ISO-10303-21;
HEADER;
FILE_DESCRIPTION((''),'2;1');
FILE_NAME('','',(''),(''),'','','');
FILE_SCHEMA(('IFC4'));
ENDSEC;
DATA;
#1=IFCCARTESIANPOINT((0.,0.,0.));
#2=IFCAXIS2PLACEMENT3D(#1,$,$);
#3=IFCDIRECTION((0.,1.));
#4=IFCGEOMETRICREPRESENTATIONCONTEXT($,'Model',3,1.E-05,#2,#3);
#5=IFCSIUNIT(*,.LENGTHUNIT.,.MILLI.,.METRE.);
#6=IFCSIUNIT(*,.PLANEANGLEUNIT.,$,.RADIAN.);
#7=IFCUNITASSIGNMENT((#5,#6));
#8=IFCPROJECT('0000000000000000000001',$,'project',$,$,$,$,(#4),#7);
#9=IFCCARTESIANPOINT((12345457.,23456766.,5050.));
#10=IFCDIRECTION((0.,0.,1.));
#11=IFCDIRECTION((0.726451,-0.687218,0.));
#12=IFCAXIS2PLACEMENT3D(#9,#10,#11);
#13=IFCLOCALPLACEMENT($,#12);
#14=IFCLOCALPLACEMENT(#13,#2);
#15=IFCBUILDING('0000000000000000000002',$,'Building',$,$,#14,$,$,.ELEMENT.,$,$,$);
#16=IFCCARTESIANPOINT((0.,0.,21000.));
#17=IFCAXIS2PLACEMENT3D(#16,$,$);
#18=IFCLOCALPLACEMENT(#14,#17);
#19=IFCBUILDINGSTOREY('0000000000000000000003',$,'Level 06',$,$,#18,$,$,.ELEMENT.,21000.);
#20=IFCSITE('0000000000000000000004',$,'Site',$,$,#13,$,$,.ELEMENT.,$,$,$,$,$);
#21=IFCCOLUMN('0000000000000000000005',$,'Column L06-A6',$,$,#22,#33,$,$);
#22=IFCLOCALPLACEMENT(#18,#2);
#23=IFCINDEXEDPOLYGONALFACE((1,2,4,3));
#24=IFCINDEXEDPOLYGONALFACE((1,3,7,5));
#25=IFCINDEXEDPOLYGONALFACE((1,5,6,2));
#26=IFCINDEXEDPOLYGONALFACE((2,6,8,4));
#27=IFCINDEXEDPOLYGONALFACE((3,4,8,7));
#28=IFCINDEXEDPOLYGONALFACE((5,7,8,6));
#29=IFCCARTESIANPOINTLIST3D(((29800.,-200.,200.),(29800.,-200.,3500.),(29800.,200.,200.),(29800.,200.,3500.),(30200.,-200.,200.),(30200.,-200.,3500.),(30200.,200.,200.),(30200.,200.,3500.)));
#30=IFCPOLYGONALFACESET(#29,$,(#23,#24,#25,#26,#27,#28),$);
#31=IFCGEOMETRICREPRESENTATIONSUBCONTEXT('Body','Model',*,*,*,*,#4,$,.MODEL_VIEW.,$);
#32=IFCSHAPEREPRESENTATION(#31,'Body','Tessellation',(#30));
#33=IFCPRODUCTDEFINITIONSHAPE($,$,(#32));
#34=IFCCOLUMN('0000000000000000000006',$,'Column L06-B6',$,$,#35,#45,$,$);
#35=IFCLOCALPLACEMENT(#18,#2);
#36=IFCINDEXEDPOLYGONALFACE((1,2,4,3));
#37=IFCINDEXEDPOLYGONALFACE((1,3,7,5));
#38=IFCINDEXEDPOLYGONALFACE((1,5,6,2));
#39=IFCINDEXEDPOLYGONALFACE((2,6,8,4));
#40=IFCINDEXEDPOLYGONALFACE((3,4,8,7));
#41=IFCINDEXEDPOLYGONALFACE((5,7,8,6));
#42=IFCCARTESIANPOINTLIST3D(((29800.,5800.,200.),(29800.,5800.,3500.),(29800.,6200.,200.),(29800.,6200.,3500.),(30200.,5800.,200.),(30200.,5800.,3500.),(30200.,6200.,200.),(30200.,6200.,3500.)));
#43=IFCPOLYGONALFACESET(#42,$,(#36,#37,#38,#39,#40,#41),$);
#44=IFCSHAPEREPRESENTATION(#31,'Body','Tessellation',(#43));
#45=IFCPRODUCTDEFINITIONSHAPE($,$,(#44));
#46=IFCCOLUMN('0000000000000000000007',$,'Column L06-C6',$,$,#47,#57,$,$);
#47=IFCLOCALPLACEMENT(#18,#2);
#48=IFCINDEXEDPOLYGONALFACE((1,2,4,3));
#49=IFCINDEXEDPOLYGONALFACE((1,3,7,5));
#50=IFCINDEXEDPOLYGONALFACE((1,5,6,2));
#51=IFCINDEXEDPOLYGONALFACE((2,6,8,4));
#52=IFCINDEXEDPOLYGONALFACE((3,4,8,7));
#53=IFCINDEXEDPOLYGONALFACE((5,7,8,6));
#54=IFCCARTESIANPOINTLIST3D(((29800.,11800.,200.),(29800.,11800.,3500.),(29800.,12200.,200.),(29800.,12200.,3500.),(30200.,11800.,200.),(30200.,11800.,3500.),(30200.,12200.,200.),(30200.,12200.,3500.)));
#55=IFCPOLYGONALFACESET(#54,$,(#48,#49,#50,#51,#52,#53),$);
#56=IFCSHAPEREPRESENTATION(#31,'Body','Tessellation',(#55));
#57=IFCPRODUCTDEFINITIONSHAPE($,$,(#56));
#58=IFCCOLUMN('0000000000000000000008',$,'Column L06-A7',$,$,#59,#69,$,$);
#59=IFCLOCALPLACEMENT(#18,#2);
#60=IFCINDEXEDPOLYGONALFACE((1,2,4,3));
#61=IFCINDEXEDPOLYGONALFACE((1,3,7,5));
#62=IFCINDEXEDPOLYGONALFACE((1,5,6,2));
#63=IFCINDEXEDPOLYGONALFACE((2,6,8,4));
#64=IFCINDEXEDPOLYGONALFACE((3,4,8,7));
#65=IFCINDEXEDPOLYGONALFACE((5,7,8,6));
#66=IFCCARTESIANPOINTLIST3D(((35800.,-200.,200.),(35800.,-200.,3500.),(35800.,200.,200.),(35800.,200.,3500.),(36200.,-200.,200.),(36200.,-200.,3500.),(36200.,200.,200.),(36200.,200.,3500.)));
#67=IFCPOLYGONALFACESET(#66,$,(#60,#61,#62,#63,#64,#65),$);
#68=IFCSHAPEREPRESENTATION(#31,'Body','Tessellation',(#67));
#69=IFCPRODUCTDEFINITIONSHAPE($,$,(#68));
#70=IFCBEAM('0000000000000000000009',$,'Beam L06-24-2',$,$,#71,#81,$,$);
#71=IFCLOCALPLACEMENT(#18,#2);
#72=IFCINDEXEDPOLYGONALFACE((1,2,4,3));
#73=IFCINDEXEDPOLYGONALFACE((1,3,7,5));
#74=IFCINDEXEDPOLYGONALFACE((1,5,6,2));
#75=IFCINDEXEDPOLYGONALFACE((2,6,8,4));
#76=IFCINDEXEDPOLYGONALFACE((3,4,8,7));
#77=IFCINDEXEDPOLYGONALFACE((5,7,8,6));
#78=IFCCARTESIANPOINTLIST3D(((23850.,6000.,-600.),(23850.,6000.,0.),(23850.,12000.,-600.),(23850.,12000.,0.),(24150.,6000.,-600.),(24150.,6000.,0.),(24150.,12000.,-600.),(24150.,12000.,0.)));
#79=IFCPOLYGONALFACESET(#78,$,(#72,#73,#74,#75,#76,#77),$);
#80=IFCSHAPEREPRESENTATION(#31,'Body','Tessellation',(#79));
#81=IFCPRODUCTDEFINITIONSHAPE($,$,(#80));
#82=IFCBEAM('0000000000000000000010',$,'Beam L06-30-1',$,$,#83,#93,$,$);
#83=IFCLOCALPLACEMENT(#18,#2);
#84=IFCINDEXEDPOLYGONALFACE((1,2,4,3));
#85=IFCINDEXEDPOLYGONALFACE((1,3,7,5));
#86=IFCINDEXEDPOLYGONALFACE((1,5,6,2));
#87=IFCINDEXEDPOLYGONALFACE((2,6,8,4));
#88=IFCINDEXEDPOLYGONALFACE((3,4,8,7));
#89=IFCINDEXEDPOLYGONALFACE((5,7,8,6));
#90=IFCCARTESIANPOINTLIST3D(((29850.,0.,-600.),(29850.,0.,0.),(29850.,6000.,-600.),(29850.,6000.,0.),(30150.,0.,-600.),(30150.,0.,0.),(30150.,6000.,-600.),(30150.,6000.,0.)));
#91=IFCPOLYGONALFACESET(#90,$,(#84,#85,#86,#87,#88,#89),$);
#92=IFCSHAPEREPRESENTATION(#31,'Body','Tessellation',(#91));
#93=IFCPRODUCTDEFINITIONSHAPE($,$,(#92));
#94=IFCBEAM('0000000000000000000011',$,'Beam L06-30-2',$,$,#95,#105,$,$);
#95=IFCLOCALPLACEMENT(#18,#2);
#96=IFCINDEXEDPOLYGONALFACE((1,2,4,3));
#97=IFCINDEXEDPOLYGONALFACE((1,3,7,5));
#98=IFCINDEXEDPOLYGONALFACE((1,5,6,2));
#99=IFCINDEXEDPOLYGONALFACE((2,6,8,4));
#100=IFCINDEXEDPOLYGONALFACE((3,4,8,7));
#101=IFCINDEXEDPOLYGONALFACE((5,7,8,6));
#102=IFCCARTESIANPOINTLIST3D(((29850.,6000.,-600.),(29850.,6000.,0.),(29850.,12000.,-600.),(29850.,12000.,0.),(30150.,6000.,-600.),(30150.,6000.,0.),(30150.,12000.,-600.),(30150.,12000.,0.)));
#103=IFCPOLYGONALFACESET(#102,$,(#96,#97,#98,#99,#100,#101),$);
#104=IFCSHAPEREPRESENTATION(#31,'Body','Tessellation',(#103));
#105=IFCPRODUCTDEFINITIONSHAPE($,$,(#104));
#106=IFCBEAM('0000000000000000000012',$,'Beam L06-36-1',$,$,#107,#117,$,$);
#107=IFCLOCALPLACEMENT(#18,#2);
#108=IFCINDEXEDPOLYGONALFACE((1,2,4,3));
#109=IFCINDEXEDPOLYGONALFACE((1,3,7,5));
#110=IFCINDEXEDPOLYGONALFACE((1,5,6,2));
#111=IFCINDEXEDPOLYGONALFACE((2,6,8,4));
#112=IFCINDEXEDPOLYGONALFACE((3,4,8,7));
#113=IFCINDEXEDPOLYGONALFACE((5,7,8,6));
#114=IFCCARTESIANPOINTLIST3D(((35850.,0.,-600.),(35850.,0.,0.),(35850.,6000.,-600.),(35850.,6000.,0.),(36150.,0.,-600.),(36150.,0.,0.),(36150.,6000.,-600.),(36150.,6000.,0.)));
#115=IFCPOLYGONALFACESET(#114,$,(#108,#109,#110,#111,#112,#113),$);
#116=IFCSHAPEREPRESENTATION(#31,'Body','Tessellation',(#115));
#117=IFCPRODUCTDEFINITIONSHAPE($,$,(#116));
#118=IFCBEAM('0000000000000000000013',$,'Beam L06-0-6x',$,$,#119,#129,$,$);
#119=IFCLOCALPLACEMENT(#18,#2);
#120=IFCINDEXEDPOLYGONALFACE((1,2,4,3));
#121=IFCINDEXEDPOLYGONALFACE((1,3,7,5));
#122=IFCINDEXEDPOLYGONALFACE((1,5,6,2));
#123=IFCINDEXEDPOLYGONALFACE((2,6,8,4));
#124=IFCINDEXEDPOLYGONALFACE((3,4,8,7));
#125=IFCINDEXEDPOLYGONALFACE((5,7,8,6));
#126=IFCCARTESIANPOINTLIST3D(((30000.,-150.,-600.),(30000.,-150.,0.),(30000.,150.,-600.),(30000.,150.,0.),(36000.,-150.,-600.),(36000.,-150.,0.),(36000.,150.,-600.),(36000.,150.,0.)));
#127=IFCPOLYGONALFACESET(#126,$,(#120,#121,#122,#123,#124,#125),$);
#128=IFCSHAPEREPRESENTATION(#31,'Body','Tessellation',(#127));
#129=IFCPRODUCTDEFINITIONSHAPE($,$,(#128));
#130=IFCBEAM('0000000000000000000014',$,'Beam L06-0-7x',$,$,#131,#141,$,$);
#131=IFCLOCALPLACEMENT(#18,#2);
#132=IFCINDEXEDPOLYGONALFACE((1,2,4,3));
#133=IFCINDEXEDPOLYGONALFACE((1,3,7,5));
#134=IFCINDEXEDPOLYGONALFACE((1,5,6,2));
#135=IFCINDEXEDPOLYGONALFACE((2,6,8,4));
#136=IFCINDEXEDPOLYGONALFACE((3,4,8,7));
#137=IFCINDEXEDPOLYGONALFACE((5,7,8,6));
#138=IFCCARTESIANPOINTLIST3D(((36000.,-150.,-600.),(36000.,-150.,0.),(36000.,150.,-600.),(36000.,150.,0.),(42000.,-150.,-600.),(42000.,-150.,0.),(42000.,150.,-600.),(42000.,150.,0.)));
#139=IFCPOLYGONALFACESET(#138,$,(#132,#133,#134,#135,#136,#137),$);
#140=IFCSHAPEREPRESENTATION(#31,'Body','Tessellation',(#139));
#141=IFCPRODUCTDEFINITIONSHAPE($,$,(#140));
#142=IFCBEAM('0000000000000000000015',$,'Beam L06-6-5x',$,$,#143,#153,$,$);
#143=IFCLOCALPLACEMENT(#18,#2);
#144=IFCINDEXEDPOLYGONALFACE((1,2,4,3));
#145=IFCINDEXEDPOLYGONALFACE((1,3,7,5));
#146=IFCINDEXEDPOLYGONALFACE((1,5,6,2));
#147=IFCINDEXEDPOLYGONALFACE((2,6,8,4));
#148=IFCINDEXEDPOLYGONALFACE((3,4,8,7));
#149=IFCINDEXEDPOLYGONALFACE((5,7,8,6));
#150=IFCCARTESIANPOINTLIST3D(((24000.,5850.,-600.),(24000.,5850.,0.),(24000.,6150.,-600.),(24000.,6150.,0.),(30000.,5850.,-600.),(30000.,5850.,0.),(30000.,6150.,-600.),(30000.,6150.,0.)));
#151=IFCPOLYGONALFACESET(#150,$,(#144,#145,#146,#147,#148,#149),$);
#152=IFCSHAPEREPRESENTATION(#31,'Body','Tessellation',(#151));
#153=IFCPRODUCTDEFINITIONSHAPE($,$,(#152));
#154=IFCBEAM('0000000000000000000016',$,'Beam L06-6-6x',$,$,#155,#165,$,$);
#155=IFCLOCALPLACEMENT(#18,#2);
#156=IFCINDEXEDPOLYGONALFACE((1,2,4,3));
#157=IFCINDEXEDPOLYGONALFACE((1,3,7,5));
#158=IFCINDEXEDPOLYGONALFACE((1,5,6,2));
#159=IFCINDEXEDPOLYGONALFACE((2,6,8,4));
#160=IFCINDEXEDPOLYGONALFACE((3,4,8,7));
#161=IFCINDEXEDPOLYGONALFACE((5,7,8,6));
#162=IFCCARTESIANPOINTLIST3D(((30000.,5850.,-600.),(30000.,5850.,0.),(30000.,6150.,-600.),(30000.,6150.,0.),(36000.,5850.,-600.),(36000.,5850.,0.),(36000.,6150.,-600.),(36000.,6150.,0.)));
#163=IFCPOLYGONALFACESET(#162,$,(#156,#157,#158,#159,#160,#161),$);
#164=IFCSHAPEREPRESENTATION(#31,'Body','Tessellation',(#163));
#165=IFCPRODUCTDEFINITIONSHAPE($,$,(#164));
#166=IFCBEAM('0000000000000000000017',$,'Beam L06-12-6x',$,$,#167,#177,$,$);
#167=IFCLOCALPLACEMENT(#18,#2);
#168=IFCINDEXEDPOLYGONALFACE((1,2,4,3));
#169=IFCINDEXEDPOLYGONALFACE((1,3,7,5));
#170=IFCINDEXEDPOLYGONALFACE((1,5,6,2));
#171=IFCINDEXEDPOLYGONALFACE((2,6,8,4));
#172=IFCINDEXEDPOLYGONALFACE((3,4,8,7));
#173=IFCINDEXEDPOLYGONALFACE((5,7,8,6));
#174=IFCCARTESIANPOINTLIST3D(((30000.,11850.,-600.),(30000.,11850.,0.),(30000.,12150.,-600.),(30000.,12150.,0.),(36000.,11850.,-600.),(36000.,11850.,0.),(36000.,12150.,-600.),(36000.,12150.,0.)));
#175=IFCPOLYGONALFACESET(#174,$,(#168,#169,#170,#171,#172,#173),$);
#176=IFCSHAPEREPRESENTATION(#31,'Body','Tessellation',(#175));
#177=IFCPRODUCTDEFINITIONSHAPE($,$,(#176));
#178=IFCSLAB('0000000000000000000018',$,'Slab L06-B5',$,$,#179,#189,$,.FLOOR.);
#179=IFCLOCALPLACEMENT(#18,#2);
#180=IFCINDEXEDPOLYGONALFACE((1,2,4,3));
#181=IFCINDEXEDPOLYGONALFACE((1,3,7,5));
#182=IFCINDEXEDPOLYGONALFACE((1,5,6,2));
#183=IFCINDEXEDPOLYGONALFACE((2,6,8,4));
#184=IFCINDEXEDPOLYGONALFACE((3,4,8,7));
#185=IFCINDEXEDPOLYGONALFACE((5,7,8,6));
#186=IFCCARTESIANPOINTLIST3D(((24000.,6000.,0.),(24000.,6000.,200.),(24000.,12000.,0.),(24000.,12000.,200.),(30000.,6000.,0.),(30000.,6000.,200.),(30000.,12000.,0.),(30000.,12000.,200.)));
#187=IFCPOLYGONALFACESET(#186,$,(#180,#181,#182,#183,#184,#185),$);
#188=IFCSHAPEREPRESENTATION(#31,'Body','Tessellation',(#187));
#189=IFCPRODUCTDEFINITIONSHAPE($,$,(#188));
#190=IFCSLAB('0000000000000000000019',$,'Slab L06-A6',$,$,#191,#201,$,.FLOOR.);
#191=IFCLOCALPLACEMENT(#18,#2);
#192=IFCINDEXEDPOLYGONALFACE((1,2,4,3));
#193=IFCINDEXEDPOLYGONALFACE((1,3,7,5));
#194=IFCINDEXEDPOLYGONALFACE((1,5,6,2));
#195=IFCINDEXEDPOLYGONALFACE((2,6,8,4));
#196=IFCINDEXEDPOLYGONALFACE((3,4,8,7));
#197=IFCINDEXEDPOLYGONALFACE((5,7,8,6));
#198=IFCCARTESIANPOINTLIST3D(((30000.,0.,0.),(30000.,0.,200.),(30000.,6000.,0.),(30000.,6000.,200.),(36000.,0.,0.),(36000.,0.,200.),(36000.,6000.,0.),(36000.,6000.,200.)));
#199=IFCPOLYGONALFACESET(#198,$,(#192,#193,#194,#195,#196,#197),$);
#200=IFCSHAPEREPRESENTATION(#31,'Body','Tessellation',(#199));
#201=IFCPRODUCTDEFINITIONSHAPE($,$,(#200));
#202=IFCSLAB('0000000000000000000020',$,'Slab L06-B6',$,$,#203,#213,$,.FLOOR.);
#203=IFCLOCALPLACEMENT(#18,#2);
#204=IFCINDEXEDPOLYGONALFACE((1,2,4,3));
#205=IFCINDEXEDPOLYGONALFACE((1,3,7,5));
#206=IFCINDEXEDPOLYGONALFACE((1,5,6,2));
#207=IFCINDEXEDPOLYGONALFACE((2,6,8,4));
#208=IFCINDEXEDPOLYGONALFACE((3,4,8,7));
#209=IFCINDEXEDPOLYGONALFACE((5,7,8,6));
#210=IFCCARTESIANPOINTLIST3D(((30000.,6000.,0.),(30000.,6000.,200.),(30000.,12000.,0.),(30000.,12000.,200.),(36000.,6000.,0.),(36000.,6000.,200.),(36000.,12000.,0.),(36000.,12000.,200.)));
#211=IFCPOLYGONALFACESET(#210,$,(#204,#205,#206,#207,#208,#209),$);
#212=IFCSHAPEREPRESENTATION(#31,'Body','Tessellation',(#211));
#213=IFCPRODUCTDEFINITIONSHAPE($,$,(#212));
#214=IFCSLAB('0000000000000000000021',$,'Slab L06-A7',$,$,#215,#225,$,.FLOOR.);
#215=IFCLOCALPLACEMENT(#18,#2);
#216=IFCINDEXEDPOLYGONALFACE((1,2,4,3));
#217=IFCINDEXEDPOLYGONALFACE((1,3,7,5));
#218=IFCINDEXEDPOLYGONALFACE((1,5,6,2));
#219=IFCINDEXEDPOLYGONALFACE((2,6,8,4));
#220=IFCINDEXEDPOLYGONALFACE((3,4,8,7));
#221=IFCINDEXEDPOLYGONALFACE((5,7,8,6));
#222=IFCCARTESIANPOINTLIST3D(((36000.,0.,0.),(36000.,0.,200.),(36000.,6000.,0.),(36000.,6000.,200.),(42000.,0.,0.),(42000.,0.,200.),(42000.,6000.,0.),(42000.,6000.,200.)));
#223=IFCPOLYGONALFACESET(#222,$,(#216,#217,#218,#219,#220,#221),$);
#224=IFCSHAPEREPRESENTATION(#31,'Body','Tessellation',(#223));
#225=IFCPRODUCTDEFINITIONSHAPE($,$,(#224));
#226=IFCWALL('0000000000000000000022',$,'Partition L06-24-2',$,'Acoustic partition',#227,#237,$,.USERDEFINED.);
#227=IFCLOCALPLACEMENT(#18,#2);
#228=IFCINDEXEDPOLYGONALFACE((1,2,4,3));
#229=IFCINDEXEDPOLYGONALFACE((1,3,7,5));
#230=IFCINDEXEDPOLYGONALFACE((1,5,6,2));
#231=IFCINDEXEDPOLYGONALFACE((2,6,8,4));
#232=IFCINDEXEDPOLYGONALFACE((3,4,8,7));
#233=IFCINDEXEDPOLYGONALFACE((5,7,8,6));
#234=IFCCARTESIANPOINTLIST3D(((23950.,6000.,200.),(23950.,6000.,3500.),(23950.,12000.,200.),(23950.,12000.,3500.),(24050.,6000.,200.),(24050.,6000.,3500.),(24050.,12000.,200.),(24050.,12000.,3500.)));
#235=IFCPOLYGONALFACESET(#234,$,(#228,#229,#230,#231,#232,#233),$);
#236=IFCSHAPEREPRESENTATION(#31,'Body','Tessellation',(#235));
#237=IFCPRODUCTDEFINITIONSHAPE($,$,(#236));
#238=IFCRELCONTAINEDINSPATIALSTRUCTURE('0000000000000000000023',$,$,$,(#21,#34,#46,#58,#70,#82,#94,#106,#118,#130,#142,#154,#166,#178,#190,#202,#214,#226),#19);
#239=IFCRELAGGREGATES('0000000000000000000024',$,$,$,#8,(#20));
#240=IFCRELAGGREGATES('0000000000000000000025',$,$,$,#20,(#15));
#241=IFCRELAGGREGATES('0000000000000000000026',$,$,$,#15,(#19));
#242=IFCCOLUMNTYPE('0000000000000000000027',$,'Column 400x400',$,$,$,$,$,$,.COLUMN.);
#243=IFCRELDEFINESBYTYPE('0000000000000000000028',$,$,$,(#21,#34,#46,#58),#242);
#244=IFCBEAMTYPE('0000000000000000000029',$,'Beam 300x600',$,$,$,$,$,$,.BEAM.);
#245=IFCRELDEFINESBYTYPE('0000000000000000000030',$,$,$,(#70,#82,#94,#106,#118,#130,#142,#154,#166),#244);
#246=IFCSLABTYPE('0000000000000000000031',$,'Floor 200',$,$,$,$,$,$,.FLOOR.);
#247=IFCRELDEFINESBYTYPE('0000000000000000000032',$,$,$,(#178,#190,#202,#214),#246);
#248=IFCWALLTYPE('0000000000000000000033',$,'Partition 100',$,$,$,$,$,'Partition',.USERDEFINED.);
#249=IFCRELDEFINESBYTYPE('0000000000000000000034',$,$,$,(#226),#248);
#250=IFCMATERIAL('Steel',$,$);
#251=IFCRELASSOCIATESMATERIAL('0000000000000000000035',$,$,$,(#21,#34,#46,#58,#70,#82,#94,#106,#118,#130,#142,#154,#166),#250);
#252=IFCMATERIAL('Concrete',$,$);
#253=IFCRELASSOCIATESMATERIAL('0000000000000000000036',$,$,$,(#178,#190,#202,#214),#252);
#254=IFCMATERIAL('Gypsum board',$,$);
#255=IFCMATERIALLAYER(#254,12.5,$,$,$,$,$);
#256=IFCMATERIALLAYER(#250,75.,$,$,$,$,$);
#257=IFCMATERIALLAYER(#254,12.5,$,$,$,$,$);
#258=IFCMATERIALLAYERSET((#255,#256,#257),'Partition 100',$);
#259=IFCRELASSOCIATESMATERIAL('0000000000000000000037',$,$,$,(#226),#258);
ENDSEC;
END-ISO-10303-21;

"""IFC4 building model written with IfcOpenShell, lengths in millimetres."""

from ifc_helpers import new_model, si_unit, direction, frame, origin, place, context, subcontext, project, spatial, rectangle, extrude, material, layer, layer_set, layer_usage, type_object, element, save


model = new_model("IFC4")

# Units and contexts
model_context = context("Model", 3, precision=1e-05, world=origin(), true_north=direction((0.0, 1.0)))
body_context = subcontext(model_context, "Body", "Model", "MODEL_VIEW")
ifc_project = project(units=[si_unit("LENGTHUNIT", "METRE", prefix="MILLI"), si_unit("PLANEANGLEUNIT", "RADIAN")], contexts=[model_context])

# Site, building, storey
site_placement = place(None, frame((12345457.0, 23456766.0, 5050.0), z_axis=(0.0, 0.0, 1.0), x_axis=(0.726451, -0.687218, 0.0)))
site = spatial("IfcSite", under=ifc_project, at=site_placement, Name="Site", CompositionType="ELEMENT")
building_placement = place(site_placement, origin())
building = spatial("IfcBuilding", under=site, at=building_placement, Name="Building", CompositionType="ELEMENT")
storey_placement = place(building_placement, frame((0.0, 0.0, 21000.0)))
storey = spatial("IfcBuildingStorey", under=building, at=storey_placement, Name="Level 06", CompositionType="ELEMENT", Elevation=21000.0)

# Columns
ifc_material_1 = material(Name="Steel")
column_type = type_object("IfcColumnType", Name="Column 400x400", PredefinedType="COLUMN")
for number, where, name in (
    (1, (29800.0, -200.0, 200.0), "Column L06-A6"),
    (2, (29800.0, 5800.0, 200.0), "Column L06-B6"),
    (3, (29800.0, 11800.0, 200.0), "Column L06-C6"),
    (4, (35800.0, -200.0, 200.0), "Column L06-A7"),
):
    element("IfcColumn", number, at=place(storey_placement, frame(where)), inside=storey, type_object=column_type, material=ifc_material_1, Name=name, context=body_context, shape_type="SweptSolid", body=[
        extrude(rectangle(XDim=400.0, YDim=400.0), frame((200.0, 200.0, 0.0)), (0.0, 0.0, 1.0), 3300.0),
    ])

# Beams
beam_type = type_object("IfcBeamType", Name="Beam 300x600", PredefinedType="BEAM")
for number, where, name in (
    (5, (23850.0, 6000.0, -600.0), "Beam L06-24-2"),
    (6, (29850.0, 0.0, -600.0), "Beam L06-30-1"),
    (7, (29850.0, 6000.0, -600.0), "Beam L06-30-2"),
    (8, (35850.0, 0.0, -600.0), "Beam L06-36-1"),
):
    element("IfcBeam", number, at=place(storey_placement, frame(where)), inside=storey, type_object=beam_type, material=ifc_material_1, Name=name, context=body_context, shape_type="SweptSolid", body=[
        extrude(rectangle(XDim=300.0, YDim=6000.0), frame((150.0, 3000.0, 0.0)), (0.0, 0.0, 1.0), 600.0),
    ])
for number, where, name in (
    (9, (30000.0, -150.0, -600.0), "Beam L06-0-6x"),
    (10, (36000.0, -150.0, -600.0), "Beam L06-0-7x"),
    (11, (24000.0, 5850.0, -600.0), "Beam L06-6-5x"),
    (12, (30000.0, 5850.0, -600.0), "Beam L06-6-6x"),
    (13, (30000.0, 11850.0, -600.0), "Beam L06-12-6x"),
):
    element("IfcBeam", number, at=place(storey_placement, frame(where)), inside=storey, type_object=beam_type, material=ifc_material_1, Name=name, context=body_context, shape_type="SweptSolid", body=[
        extrude(rectangle(XDim=6000.0, YDim=300.0), frame((3000.0, 150.0, 0.0)), (0.0, 0.0, 1.0), 600.0),
    ])

# Slabs
ifc_material_2 = material(Name="Concrete")
slab_type = type_object("IfcSlabType", Name="Floor 200", PredefinedType="FLOOR")
for number, where, name in (
    (14, (24000.0, 6000.0, 0.0), "Slab L06-B5"),
    (15, (30000.0, 0.0, 0.0), "Slab L06-A6"),
    (16, (30000.0, 6000.0, 0.0), "Slab L06-B6"),
    (17, (36000.0, 0.0, 0.0), "Slab L06-A7"),
):
    element("IfcSlab", number, at=place(storey_placement, frame(where)), inside=storey, type_object=slab_type, material=ifc_material_2, Name=name, PredefinedType="FLOOR", context=body_context, shape_type="SweptSolid", body=[
        extrude(rectangle(XDim=6000.0, YDim=6000.0), frame((3000.0, 3000.0, 0.0)), (0.0, 0.0, 1.0), 200.0),
    ])

# Wall
ifc_material_3 = material(Name="Gypsum board")
ifc_layer_1 = layer(ifc_material_3, 12.5)
ifc_layer_2 = layer(ifc_material_1, 75.0)
ifc_layer_3 = layer(ifc_material_3, 12.5)
ifc_layer_set = layer_set([ifc_layer_1, ifc_layer_2, ifc_layer_3], Name="Partition 100")
ifc_layer_usage = layer_usage(ifc_layer_set, "AXIS2", "POSITIVE", 0.0)
wall_type = type_object("IfcWallType", Name="Partition 100", ElementType="Partition", PredefinedType="USERDEFINED")
for number, where, name in (
    (18, (23950.0, 6000.0, 200.0), "Partition L06-24-2"),
):
    element("IfcWall", number, at=place(storey_placement, frame(where)), inside=storey, type_object=wall_type, material=ifc_layer_usage, Name=name, ObjectType="Acoustic partition", PredefinedType="USERDEFINED", context=body_context, shape_type="SweptSolid", body=[
        extrude(rectangle(XDim=100.0, YDim=6000.0), frame((50.0, 3000.0, 0.0)), (0.0, 0.0, 1.0), 3300.0),
    ])

save(model, "model.ifc")
